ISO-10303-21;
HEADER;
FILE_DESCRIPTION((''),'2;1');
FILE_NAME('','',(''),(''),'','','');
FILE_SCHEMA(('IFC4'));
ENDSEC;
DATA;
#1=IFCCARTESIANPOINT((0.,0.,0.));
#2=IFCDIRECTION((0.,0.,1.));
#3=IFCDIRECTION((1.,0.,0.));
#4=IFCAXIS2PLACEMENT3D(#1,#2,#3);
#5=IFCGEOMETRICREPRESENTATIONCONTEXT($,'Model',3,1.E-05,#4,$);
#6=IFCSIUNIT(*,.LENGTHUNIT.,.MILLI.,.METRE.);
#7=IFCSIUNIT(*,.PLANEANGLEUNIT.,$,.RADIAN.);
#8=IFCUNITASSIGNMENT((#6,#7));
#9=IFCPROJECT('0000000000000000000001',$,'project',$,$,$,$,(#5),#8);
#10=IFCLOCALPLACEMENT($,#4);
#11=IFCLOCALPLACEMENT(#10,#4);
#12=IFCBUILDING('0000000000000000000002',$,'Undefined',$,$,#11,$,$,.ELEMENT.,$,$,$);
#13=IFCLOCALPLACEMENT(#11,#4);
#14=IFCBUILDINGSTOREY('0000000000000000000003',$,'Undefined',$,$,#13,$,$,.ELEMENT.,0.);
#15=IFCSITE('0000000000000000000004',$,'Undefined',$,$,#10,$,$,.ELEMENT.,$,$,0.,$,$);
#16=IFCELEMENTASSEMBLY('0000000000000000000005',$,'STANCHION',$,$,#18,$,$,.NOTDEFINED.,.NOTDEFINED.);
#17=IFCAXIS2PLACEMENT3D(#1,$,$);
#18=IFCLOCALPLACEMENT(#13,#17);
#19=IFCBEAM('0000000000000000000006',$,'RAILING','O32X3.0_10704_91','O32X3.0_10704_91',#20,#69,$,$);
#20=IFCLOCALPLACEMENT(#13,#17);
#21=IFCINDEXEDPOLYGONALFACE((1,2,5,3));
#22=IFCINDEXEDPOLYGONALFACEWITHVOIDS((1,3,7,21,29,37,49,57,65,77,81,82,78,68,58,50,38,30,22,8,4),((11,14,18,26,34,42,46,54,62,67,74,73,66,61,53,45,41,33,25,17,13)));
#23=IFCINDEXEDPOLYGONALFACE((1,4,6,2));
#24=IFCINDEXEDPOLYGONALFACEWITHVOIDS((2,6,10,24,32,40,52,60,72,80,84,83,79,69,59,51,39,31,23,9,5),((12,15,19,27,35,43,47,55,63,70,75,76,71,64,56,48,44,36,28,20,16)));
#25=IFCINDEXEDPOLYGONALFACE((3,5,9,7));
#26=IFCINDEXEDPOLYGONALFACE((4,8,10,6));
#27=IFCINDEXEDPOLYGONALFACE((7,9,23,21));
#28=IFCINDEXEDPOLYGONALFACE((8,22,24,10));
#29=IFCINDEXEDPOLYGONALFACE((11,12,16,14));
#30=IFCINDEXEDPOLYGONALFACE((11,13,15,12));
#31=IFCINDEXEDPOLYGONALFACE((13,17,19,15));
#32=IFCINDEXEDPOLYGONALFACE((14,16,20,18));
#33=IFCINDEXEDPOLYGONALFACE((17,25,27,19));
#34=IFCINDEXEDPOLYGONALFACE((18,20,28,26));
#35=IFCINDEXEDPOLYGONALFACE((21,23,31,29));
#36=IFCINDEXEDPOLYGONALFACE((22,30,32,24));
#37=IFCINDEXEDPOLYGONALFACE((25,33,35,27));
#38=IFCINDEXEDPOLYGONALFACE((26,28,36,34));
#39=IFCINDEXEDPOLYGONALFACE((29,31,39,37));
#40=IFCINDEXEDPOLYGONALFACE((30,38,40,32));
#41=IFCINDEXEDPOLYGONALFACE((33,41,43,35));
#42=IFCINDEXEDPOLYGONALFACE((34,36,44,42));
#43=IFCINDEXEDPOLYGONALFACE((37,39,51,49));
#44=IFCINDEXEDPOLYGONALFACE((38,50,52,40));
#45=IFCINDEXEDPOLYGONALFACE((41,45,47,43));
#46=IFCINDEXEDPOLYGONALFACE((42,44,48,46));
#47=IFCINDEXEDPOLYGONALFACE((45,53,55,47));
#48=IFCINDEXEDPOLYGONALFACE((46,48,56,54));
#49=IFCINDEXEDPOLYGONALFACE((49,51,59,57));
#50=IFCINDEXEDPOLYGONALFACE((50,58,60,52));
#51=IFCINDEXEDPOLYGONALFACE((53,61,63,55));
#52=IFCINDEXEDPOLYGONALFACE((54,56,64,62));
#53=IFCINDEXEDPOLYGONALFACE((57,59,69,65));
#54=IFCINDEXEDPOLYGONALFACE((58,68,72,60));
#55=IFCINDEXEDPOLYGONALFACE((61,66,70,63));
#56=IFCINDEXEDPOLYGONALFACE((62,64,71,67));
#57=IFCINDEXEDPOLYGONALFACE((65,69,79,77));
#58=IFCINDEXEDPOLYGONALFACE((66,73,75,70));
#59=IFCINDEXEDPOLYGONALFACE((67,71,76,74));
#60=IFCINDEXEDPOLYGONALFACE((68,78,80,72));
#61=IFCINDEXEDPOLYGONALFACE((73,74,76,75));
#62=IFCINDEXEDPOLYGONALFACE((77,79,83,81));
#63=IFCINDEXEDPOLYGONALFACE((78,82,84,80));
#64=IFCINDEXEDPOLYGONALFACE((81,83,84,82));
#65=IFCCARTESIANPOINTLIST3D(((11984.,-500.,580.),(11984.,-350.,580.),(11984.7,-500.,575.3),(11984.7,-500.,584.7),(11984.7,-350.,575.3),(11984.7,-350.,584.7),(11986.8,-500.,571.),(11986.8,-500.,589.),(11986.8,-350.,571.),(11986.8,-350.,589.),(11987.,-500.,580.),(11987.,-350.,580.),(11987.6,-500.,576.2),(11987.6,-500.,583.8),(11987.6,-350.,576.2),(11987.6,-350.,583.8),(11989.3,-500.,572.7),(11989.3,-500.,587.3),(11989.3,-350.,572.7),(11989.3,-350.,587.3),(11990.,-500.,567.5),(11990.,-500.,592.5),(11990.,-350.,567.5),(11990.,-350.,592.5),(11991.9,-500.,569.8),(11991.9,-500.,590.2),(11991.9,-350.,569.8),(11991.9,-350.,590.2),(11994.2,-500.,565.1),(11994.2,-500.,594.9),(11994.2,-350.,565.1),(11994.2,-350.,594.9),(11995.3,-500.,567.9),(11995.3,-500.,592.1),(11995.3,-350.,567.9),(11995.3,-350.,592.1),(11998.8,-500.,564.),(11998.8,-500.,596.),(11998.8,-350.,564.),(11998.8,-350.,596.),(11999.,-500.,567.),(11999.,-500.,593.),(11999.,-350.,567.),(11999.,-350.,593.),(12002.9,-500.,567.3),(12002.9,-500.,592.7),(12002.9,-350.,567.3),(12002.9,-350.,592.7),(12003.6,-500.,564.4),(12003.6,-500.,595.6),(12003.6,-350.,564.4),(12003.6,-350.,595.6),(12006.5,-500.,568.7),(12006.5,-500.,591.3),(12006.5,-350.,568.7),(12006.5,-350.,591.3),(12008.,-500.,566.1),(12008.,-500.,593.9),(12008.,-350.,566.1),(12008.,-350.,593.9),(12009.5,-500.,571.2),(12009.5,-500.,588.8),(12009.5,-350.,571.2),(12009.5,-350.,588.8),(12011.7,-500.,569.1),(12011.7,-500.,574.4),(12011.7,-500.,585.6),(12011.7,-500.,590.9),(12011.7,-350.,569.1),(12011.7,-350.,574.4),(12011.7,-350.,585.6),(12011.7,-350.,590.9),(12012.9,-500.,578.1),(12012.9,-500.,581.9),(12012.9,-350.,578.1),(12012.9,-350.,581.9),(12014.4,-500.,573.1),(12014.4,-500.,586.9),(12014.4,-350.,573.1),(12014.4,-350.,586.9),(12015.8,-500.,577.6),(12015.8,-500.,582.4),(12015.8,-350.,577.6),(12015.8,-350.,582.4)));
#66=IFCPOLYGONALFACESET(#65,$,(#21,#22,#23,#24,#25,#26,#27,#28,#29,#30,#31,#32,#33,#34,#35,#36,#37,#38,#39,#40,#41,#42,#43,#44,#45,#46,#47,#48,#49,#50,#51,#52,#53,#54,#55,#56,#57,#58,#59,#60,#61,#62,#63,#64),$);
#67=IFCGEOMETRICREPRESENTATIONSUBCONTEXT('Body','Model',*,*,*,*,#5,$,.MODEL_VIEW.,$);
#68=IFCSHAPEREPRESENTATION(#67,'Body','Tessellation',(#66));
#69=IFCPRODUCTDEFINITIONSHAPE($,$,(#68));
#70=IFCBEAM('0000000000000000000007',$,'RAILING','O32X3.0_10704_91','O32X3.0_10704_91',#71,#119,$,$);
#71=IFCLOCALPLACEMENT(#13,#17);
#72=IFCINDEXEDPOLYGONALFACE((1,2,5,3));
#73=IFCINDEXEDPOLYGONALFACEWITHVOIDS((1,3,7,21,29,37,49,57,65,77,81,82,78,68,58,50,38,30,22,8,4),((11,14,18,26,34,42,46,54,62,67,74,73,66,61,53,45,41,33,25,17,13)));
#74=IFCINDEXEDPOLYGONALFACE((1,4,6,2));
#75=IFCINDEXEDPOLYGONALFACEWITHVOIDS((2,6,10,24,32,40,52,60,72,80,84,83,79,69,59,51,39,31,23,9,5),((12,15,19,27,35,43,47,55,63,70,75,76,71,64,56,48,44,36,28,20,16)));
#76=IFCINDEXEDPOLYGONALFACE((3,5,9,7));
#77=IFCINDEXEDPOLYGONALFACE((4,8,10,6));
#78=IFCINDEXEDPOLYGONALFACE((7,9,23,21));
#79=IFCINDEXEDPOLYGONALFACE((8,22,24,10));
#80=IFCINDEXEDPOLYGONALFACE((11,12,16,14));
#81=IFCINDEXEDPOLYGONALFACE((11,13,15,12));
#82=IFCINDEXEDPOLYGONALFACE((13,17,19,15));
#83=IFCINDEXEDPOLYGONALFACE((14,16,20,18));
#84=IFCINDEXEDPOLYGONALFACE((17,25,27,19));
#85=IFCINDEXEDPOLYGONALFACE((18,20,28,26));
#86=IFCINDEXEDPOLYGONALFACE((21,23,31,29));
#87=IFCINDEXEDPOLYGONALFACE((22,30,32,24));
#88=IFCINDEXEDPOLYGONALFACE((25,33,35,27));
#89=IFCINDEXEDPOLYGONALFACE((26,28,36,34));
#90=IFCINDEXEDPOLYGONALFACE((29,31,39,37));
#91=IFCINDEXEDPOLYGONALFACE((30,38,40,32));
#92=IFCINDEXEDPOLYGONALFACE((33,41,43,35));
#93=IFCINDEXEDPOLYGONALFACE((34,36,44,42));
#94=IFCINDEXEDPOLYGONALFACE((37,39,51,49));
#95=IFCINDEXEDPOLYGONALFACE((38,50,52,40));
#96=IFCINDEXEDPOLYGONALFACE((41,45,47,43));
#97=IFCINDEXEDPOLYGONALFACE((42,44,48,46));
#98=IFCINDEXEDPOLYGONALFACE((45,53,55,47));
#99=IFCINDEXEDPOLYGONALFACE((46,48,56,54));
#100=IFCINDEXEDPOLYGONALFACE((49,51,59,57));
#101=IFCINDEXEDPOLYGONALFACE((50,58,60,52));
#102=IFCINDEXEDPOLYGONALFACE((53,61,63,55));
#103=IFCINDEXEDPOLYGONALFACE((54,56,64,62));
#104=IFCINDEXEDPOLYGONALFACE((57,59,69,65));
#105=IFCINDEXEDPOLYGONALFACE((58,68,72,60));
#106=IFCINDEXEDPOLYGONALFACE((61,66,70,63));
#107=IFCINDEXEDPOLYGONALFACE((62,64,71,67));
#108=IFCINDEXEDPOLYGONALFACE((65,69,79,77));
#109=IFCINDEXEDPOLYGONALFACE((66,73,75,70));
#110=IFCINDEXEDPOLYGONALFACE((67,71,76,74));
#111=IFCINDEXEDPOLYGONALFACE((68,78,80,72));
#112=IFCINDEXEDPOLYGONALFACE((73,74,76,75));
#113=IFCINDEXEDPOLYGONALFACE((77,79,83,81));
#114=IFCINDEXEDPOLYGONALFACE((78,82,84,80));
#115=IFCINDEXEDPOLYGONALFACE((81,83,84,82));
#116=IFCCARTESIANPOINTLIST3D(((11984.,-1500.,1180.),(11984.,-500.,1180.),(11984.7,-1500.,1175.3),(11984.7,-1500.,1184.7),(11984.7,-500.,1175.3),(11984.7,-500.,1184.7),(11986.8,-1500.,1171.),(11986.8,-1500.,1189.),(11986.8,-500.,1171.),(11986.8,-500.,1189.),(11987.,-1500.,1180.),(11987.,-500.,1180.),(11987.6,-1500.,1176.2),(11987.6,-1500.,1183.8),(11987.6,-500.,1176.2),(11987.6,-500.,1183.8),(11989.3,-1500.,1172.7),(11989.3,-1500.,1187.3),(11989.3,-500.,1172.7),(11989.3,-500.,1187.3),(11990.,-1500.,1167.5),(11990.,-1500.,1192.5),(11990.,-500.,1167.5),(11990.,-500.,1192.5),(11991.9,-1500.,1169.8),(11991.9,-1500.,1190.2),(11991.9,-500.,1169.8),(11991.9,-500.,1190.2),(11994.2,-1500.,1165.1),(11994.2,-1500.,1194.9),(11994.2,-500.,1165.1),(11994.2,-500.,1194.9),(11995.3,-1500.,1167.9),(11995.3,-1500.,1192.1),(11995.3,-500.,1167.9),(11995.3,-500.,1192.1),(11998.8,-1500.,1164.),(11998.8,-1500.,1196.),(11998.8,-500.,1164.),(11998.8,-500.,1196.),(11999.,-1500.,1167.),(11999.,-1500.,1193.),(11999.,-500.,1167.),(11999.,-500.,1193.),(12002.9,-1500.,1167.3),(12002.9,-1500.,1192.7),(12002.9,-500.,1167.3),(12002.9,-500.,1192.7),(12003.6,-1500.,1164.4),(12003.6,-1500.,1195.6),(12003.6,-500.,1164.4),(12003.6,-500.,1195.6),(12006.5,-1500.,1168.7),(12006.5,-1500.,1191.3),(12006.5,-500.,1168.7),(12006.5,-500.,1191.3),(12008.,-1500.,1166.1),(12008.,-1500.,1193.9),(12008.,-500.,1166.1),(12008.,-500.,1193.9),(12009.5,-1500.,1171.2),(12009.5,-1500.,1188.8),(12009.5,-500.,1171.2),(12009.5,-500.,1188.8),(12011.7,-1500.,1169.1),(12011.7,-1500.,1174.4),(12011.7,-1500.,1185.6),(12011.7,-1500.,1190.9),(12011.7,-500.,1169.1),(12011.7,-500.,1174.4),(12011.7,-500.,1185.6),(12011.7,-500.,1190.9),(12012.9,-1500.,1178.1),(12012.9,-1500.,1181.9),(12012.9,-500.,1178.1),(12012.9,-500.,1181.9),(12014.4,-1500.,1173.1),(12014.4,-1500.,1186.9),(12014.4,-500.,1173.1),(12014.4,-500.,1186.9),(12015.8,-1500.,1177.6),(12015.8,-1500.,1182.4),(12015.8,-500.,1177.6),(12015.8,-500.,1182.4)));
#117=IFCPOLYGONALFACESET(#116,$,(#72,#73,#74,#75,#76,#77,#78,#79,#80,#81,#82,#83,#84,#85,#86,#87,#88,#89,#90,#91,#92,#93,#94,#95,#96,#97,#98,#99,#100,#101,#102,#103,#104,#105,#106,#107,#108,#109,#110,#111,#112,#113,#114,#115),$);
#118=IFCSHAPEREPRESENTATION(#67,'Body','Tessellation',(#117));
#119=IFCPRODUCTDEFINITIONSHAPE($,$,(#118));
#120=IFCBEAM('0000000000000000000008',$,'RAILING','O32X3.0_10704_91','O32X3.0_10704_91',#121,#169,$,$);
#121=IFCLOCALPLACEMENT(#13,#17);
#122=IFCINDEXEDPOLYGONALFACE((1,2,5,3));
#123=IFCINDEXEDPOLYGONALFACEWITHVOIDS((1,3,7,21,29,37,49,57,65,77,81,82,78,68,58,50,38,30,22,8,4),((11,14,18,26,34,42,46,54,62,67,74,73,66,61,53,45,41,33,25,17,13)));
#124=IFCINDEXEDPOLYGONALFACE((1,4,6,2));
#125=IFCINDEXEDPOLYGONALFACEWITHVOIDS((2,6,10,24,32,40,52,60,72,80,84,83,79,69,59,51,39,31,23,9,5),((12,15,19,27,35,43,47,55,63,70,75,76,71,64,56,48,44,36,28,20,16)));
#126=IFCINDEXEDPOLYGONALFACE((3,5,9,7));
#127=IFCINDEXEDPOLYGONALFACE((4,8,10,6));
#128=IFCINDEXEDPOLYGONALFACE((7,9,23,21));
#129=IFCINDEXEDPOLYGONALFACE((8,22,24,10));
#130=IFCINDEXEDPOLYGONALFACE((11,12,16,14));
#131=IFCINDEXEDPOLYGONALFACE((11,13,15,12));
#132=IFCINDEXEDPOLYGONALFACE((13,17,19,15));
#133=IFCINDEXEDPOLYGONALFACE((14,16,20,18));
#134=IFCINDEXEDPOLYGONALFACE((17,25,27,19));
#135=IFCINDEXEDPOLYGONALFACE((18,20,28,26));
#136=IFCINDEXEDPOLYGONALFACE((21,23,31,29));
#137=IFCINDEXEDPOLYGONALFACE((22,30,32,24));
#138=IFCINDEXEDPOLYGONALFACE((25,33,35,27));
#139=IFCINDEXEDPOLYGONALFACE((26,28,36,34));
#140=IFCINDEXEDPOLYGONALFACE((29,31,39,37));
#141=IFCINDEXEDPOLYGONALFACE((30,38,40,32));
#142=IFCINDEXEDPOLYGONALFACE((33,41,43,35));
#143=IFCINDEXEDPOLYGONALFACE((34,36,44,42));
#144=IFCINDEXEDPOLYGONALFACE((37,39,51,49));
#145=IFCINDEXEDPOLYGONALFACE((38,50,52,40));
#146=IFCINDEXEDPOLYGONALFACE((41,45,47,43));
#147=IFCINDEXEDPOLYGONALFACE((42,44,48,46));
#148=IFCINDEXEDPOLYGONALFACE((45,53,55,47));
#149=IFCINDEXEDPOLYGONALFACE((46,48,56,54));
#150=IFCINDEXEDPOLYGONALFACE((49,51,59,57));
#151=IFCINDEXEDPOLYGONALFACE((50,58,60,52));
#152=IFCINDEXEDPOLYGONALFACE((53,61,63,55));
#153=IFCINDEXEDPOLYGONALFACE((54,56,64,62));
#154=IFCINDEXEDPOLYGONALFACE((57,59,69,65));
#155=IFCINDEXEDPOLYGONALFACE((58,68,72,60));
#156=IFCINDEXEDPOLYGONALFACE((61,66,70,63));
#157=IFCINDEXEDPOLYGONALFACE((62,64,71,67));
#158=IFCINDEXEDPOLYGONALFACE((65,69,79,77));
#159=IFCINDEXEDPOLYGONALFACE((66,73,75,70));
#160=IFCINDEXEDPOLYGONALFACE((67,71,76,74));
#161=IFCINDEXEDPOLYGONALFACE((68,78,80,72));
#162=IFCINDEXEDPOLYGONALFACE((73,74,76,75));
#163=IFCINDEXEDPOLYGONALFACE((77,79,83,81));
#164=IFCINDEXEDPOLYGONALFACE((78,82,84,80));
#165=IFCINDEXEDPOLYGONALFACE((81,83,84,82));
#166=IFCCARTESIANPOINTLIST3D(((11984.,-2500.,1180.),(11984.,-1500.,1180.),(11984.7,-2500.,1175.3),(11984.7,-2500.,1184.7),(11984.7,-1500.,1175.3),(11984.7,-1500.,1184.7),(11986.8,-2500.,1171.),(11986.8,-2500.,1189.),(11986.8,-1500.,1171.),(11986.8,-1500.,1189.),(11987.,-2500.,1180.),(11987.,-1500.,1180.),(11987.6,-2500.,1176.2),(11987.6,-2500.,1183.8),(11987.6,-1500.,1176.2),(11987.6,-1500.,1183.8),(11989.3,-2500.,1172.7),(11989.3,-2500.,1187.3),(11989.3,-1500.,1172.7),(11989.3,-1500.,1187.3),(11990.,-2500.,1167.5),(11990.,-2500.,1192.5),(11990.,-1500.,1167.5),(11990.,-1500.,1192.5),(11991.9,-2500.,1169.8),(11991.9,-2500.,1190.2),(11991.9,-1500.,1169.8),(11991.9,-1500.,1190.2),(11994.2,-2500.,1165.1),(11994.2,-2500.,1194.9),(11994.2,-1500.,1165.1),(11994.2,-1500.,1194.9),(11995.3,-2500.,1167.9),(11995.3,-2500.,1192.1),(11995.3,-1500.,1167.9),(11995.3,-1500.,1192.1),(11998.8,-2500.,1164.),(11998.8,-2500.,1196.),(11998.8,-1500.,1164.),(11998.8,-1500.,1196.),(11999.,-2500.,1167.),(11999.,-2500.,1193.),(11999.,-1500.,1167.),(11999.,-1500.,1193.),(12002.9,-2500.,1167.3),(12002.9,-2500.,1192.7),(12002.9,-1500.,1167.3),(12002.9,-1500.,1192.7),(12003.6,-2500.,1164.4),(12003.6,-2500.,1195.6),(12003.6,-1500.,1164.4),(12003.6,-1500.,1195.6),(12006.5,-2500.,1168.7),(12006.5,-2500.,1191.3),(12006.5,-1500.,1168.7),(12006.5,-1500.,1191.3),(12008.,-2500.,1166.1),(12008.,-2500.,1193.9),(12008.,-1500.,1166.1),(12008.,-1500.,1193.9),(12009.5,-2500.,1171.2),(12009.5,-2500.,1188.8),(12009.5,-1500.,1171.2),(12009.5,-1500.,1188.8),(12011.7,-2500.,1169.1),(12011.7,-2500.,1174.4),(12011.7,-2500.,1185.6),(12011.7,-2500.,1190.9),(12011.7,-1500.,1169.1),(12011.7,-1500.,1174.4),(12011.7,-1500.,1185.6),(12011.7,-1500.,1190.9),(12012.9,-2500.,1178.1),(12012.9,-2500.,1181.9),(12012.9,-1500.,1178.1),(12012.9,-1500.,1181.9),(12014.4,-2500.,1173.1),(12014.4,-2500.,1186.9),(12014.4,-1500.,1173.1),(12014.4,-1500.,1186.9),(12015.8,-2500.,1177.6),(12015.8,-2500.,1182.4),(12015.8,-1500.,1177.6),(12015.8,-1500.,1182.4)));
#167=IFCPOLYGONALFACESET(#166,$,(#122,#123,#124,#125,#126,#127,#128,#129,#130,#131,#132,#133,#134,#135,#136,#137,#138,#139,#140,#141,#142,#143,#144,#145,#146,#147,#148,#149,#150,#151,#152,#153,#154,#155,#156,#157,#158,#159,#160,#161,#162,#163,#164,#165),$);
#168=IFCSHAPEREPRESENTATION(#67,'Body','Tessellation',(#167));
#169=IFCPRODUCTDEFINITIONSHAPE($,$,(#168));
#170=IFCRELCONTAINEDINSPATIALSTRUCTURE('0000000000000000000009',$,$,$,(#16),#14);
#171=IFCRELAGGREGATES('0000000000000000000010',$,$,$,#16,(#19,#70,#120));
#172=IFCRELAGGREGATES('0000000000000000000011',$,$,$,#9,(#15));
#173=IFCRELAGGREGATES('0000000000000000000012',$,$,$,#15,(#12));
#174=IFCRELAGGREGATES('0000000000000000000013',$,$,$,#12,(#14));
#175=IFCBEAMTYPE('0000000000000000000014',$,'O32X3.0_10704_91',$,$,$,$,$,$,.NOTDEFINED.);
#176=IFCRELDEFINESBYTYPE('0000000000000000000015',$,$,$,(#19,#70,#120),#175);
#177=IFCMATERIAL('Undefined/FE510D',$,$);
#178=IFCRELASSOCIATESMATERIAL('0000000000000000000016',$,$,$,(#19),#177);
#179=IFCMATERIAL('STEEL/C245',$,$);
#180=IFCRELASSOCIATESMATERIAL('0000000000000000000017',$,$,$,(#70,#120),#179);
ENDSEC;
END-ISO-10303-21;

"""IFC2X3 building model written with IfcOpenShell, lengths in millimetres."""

from ifc_helpers import new_model, si_unit, frame, origin_with_axes, origin_2d_with_axis, place, context, subcontext, project, spatial, hollow_circle, extrude, material, type_object, element, aggregate, save


model = new_model("IFC2X3")

# Units and contexts
model_context = context("Model", 3, precision=1e-05, world=origin_with_axes())
body_context = subcontext(model_context, "Body", "Model", "MODEL_VIEW")
ifc_project = project(units=[si_unit("LENGTHUNIT", "METRE", prefix="MILLI"), si_unit("PLANEANGLEUNIT", "RADIAN")], contexts=[model_context])

# Site, building, storey
site_placement = place(None, origin_with_axes())
site = spatial("IfcSite", under=ifc_project, at=site_placement, Name="Undefined", CompositionType="ELEMENT", RefElevation=0.0)
building_placement = place(site_placement, origin_with_axes())
building = spatial("IfcBuilding", under=site, at=building_placement, Name="Undefined", CompositionType="ELEMENT")
storey_placement = place(building_placement, origin_with_axes())
storey = spatial("IfcBuildingStorey", under=building, at=storey_placement, Name="Undefined", CompositionType="ELEMENT", Elevation=0.0)

# Element assembly
ifc_material_1 = material(Name="STEEL/C245")
assembly_1_placement = place(storey_placement, origin_with_axes())
assembly_1 = element("IfcElementAssembly", 1, at=assembly_1_placement, inside=storey, Name="STANCHION", AssemblyPlace="NOTDEFINED", PredefinedType="NOTDEFINED")
ifc_material_2 = material(Name="Undefined/FE510D")

# Beams
beam_type_1 = type_object("IfcBeamType", Name="O32X3.0_10704_91", PredefinedType="NOTDEFINED")
beam_1_placement = place(assembly_1_placement, frame((12000.0, -500.0, 580.0), z_axis=(0.0, 0.0, -1.0), x_axis=(0.0, 1.0, 0.0)))
beam_1 = element("IfcBeam", 2, at=beam_1_placement, type_object=beam_type_1, material=ifc_material_2, Name="RAILING", Description="O32X3.0_10704_91", ObjectType="O32X3.0_10704_91", context=body_context, shape_type="SweptSolid", body=[
    extrude(hollow_circle(Radius=16.0, WallThickness=3.0, at=origin_2d_with_axis()), frame((150.0, 0.0, 0.0), z_axis=(-1.0, 0.0, 0.0), x_axis=(0.0, -1.0, 0.0)), (0.0, 0.0, 1.0), 150.0),
])
beam_2_placement = place(assembly_1_placement, frame((12000.0, -1500.0, 1180.0), z_axis=(0.0, 0.0, -1.0), x_axis=(0.0, 1.0, 0.0)))
beam_2 = element("IfcBeam", 3, at=beam_2_placement, type_object=beam_type_1, material=ifc_material_1, Name="RAILING", Description="O32X3.0_10704_91", ObjectType="O32X3.0_10704_91", context=body_context, shape_type="SweptSolid", body=[
    extrude(hollow_circle(Radius=16.0, WallThickness=3.0, at=origin_2d_with_axis()), frame((1000.0, 0.0, 0.0), z_axis=(-1.0, 0.0, 0.0), x_axis=(0.0, -1.0, 0.0)), (0.0, 0.0, 1.0), 1000.0),
])
beam_3_placement = place(assembly_1_placement, frame((12000.0, -2500.0, 1180.0), z_axis=(0.0, 0.0, -1.0), x_axis=(0.0, 1.0, 0.0)))
beam_3 = element("IfcBeam", 4, at=beam_3_placement, type_object=beam_type_1, material=ifc_material_1, Name="RAILING", Description="O32X3.0_10704_91", ObjectType="O32X3.0_10704_91", context=body_context, shape_type="SweptSolid", body=[
    extrude(hollow_circle(Radius=16.0, WallThickness=3.0, at=origin_2d_with_axis()), frame((1000.0, 0.0, 0.0), z_axis=(-1.0, 0.0, 0.0), x_axis=(0.0, -1.0, 0.0)), (0.0, 0.0, 1.0), 1000.0),
])
aggregate(assembly_1, [beam_1, beam_2, beam_3])

save(model, "model.ifc")
